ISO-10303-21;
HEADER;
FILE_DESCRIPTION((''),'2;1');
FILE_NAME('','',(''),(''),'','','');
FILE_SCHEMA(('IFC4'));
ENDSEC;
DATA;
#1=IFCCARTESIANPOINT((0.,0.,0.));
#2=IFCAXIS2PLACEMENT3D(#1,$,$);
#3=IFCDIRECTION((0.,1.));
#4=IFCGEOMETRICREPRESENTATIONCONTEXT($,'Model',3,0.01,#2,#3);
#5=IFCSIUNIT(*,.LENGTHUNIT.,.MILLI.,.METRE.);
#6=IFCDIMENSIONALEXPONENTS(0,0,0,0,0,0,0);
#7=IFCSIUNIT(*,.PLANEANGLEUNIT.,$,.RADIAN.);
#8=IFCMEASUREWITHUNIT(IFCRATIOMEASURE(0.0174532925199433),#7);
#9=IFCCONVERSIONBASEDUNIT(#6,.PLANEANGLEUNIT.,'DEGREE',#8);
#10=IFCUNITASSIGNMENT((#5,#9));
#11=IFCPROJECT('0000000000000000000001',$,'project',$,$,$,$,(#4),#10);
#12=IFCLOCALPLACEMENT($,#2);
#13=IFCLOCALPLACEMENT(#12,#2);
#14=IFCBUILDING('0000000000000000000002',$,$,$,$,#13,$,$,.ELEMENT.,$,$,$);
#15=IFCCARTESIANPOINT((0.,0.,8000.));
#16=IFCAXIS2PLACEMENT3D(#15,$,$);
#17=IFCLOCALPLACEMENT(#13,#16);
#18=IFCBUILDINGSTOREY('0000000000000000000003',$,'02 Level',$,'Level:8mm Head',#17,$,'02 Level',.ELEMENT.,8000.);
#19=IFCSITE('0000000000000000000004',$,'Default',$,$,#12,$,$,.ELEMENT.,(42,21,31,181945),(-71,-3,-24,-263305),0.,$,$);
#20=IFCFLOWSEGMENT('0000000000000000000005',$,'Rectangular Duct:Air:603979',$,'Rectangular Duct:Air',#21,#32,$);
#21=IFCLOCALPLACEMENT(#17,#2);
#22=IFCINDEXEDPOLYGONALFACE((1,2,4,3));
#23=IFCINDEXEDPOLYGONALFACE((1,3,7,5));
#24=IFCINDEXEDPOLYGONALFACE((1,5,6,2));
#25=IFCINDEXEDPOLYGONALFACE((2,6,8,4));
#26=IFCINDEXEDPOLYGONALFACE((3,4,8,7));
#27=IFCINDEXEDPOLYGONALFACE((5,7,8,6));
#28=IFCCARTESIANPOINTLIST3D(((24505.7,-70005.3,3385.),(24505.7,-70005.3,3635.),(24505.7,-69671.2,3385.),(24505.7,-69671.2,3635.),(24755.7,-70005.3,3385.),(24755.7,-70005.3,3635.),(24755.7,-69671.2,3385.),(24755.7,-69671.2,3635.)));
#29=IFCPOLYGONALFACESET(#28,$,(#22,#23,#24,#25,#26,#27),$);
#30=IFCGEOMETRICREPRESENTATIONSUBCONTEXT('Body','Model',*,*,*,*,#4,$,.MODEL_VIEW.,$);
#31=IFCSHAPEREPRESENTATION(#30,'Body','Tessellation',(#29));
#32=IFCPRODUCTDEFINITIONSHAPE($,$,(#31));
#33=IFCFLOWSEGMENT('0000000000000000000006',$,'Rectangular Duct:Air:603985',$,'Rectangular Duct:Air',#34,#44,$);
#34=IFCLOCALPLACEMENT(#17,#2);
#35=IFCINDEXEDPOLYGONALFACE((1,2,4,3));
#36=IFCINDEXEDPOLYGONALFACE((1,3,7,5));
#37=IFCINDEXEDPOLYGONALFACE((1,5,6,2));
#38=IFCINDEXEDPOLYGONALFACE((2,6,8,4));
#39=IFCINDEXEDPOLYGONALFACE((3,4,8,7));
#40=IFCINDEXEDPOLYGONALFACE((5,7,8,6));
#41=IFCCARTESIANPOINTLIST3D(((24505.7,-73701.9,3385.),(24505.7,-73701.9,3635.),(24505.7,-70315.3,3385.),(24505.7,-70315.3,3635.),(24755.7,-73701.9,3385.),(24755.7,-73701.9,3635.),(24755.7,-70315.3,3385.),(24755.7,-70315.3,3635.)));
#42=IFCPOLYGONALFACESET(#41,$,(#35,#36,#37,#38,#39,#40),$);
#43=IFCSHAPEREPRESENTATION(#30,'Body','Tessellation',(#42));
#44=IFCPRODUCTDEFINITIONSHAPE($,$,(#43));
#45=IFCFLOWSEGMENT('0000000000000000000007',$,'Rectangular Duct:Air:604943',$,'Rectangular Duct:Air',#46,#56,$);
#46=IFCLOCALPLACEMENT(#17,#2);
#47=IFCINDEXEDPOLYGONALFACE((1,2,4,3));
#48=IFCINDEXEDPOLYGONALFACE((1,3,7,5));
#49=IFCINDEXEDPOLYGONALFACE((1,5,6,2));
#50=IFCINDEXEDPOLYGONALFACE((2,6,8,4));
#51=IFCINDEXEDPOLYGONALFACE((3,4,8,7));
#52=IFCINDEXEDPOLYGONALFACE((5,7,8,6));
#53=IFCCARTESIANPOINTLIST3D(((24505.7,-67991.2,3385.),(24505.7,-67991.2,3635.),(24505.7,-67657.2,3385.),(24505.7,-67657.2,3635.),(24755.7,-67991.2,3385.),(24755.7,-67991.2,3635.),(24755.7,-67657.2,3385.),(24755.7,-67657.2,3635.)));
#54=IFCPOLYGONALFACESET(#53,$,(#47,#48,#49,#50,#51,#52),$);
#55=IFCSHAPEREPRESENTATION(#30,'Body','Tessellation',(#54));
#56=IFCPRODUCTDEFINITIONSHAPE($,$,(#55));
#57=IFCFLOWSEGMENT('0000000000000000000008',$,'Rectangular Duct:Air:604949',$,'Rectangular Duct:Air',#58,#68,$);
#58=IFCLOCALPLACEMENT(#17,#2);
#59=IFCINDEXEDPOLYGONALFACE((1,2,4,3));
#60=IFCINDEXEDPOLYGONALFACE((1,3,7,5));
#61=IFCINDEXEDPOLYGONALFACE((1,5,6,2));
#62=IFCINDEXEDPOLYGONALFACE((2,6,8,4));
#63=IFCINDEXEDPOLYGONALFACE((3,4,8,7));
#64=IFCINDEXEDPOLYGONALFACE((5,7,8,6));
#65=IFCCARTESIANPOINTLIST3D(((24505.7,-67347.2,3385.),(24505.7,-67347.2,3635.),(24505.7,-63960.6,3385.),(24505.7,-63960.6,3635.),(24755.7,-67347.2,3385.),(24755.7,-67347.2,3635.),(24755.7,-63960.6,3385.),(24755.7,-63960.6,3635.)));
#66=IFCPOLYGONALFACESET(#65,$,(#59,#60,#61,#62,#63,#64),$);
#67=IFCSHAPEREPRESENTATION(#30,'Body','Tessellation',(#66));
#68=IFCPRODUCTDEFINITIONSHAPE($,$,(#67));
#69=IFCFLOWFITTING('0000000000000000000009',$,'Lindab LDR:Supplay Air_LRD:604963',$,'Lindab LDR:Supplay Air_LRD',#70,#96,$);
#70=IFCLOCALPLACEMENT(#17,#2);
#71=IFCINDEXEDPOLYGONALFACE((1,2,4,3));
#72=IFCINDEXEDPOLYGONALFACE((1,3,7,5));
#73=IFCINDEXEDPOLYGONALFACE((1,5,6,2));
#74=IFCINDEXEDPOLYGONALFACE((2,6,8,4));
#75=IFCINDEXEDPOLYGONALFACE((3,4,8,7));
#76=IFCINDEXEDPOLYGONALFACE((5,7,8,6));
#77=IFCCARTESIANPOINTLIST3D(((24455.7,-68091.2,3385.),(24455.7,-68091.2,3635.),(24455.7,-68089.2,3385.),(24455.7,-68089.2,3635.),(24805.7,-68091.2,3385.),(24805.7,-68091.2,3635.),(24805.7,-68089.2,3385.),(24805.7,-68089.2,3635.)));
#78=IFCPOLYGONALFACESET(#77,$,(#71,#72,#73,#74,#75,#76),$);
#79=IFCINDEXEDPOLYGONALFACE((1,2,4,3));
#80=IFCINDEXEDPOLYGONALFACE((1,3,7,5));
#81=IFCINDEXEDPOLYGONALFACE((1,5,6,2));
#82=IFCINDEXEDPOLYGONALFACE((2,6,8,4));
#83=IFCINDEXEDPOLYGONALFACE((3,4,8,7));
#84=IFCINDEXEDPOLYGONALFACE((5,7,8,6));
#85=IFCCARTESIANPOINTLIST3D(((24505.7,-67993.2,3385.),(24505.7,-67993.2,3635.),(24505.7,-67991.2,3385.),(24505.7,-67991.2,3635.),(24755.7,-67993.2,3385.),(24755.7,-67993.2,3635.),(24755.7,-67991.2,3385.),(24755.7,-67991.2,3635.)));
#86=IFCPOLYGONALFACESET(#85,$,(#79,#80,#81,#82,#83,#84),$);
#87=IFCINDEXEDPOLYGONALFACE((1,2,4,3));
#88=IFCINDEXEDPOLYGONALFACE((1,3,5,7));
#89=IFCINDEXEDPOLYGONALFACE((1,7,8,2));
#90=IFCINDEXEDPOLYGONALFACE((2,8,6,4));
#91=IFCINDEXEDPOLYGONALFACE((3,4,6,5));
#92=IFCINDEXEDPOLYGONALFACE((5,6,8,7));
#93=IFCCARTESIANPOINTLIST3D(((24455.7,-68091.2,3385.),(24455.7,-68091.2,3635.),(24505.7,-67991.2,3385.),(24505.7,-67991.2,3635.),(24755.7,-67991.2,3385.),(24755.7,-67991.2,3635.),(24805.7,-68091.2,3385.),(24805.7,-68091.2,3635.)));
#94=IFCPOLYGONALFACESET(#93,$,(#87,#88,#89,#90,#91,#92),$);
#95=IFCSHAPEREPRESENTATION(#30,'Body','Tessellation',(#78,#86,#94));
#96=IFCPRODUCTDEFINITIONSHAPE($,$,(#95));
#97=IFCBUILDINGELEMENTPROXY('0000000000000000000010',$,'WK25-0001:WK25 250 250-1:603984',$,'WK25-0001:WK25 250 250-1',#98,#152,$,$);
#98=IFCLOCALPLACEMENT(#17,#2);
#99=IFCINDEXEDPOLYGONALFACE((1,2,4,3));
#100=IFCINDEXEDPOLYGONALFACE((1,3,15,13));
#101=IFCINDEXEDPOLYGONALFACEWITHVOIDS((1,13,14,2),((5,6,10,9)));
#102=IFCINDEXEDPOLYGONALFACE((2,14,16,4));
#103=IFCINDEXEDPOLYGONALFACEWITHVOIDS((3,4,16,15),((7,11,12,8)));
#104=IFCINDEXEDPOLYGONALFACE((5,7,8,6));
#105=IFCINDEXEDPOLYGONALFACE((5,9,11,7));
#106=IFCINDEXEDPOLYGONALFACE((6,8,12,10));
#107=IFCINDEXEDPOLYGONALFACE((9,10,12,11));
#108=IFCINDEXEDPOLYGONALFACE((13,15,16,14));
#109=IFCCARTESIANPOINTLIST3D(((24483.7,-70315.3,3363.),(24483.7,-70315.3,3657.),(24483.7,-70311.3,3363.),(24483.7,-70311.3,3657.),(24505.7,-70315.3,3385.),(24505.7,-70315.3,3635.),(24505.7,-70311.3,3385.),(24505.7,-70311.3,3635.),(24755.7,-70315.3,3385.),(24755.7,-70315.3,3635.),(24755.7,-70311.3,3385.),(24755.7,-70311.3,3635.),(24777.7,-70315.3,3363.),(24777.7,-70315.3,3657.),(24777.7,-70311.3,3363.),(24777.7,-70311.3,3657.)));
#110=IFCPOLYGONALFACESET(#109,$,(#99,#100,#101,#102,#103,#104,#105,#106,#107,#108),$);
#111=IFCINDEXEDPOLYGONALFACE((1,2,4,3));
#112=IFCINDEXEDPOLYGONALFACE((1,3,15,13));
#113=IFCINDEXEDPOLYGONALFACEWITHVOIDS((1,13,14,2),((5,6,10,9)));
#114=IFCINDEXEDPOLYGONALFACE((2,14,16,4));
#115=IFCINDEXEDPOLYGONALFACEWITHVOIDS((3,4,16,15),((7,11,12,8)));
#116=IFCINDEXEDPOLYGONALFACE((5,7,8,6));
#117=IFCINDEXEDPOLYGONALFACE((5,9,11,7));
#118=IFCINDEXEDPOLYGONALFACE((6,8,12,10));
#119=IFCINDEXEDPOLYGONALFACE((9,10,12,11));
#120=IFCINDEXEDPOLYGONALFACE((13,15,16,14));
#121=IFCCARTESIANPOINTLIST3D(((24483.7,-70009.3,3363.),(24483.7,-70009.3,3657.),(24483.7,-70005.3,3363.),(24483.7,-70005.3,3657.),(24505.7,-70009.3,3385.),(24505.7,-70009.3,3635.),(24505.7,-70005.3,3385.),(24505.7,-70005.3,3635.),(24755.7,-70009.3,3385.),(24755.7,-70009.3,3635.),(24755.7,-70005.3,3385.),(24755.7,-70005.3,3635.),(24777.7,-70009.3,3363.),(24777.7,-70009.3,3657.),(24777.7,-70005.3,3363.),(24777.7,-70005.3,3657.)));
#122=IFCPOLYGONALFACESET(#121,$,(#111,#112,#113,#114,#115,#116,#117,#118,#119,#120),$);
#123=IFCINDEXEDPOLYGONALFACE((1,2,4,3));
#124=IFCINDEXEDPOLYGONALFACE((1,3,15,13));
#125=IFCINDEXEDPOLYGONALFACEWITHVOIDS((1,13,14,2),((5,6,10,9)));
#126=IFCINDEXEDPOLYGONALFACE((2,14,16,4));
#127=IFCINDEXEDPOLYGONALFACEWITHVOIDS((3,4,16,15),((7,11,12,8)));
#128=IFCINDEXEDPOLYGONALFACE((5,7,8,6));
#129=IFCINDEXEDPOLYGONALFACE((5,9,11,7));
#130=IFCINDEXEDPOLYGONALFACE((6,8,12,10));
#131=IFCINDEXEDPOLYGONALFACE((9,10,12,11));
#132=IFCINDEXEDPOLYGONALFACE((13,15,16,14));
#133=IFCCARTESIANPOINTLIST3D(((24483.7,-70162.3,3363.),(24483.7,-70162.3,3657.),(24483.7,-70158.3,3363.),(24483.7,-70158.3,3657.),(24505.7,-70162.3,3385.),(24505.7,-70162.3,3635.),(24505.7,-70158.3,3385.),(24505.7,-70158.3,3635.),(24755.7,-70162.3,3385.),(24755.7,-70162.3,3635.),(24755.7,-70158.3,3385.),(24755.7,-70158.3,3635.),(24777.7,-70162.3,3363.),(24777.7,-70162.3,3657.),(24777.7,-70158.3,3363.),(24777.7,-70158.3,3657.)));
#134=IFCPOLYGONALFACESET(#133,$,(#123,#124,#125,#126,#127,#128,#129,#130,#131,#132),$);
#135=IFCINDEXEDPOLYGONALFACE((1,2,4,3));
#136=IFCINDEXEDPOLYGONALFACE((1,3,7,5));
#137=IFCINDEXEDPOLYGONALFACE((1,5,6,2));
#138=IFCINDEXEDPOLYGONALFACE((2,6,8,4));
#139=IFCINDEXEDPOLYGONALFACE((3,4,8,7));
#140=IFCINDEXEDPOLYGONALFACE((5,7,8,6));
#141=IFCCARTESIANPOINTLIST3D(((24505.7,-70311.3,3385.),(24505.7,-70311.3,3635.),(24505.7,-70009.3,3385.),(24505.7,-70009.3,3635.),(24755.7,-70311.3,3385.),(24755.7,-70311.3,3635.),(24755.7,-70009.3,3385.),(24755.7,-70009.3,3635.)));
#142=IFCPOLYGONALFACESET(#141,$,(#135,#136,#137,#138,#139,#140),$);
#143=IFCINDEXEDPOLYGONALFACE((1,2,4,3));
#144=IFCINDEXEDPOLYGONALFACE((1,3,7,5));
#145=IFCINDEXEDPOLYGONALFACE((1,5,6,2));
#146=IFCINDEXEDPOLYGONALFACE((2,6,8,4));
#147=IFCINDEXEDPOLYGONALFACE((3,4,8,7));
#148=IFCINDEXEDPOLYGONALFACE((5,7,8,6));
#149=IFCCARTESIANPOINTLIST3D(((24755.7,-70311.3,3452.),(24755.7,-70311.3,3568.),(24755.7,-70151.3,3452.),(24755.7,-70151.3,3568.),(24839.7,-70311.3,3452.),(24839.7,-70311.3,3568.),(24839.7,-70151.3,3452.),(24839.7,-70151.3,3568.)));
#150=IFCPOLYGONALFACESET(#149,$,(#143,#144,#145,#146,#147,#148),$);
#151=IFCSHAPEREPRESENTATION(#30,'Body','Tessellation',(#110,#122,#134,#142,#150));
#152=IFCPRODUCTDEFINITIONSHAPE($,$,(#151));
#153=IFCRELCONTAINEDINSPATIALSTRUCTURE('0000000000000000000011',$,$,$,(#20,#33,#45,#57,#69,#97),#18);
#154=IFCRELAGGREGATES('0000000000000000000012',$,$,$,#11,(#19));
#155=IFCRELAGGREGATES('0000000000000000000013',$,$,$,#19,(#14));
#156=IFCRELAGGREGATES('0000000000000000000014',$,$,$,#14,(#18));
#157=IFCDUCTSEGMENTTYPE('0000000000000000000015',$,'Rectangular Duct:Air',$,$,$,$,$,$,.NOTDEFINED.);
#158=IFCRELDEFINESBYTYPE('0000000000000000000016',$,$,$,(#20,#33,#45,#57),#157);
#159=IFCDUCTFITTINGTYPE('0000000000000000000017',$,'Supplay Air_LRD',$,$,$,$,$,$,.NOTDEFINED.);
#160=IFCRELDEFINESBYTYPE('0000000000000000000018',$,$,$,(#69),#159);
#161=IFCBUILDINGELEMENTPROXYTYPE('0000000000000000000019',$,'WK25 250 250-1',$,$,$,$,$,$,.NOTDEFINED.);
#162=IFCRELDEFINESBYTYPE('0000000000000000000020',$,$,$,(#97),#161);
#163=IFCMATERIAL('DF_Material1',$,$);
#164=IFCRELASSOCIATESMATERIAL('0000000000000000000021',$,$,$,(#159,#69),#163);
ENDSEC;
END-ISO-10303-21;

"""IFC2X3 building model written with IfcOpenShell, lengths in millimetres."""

from ifc_helpers import new_model, entity, si_unit, converted_unit, direction, frame, frame_2d, origin, origin_2d_with_axis, place, context, subcontext, project, spatial, polyline, rectangle, outline, extrude, source, transform, mapped, material, type_object, type_shapes, element, save


model = new_model("IFC2X3")

# Units and contexts
model_context = context("Model", 3, precision=0.01, world=origin(), true_north=direction((0.0, 1.0)))
body_context = subcontext(model_context, "Body", "Model", "MODEL_VIEW")
ifc_project = project(units=[si_unit("LENGTHUNIT", "METRE", prefix="MILLI"), converted_unit("PLANEANGLEUNIT", "DEGREE", entity("IfcRatioMeasure", 0.0174532925199433), si_unit("PLANEANGLEUNIT", "RADIAN"), dimensions=[0, 0, 0, 0, 0, 0, 0])], contexts=[model_context])

# Site, building, storey
site_placement = place(None, origin())
site = spatial("IfcSite", under=ifc_project, at=site_placement, Name="Default", CompositionType="ELEMENT", RefLatitude=(42, 21, 31, 181945), RefLongitude=(-71, -3, -24, -263305), RefElevation=0.0)
building_placement = place(site_placement, origin())
building = spatial("IfcBuilding", under=site, at=building_placement, CompositionType="ELEMENT")
storey_placement = place(building_placement, frame((0.0, 0.0, 8000.0)))
storey = spatial("IfcBuildingStorey", under=building, at=storey_placement, Name="02 Level", ObjectType="Level:8mm Head", LongName="02 Level", CompositionType="ELEMENT", Elevation=8000.0)

# Flow segments
duct_segment_type_1 = type_object("IfcDuctSegmentType", Name="Rectangular Duct:Air", PredefinedType="NOTDEFINED")
flow_segment_1_placement = place(storey_placement, frame((24505.7, -70005.3, 3385.0)))
element("IfcFlowSegment", 1, at=flow_segment_1_placement, inside=storey, type_object=duct_segment_type_1, Name="Rectangular Duct:Air:603979", ObjectType="Rectangular Duct:Air", context=body_context, shape_type="SweptSolid", body=[
    extrude(rectangle(XDim=334.0, YDim=250.0, at=frame_2d((0.0, 0.0), x_axis=(1.0, 0.0))), frame((125.0, 167.0, 0.0), z_axis=(0.0, 0.0, 1.0), x_axis=(0.0, 1.0, 0.0)), (0.0, 0.0, 1.0), 250.0),
])
flow_segment_2_placement = place(storey_placement, frame((24505.7, -73701.9, 3385.0)))
element("IfcFlowSegment", 2, at=flow_segment_2_placement, inside=storey, type_object=duct_segment_type_1, Name="Rectangular Duct:Air:603985", ObjectType="Rectangular Duct:Air", context=body_context, shape_type="SweptSolid", body=[
    extrude(rectangle(XDim=3386.6, YDim=250.0, at=frame_2d((0.0, 0.0), x_axis=(1.0, 0.0))), frame((125.0, 1693.3, 0.0), z_axis=(0.0, 0.0, 1.0), x_axis=(0.0, 1.0, 0.0)), (0.0, 0.0, 1.0), 250.0),
])
flow_segment_3_placement = place(storey_placement, frame((24505.7, -67991.2, 3385.0)))
element("IfcFlowSegment", 3, at=flow_segment_3_placement, inside=storey, type_object=duct_segment_type_1, Name="Rectangular Duct:Air:604943", ObjectType="Rectangular Duct:Air", context=body_context, shape_type="SweptSolid", body=[
    extrude(rectangle(XDim=334.0, YDim=250.0, at=frame_2d((0.0, 0.0), x_axis=(1.0, 0.0))), frame((125.0, 167.0, 0.0), z_axis=(0.0, 0.0, 1.0), x_axis=(0.0, -1.0, 0.0)), (0.0, 0.0, 1.0), 250.0),
])
flow_segment_4_placement = place(storey_placement, frame((24505.7, -67347.2, 3385.0)))
element("IfcFlowSegment", 4, at=flow_segment_4_placement, inside=storey, type_object=duct_segment_type_1, Name="Rectangular Duct:Air:604949", ObjectType="Rectangular Duct:Air", context=body_context, shape_type="SweptSolid", body=[
    extrude(rectangle(XDim=3386.6, YDim=250.0, at=frame_2d((0.0, 0.0), x_axis=(1.0, 0.0))), frame((125.0, 1693.3, 0.0), z_axis=(0.0, 0.0, 1.0), x_axis=(0.0, -1.0, 0.0)), (0.0, 0.0, 1.0), 250.0),
])

# Flow fitting
ifc_material = material(Name="DF_Material1")
duct_fitting_type_1 = type_object("IfcDuctFittingType", Name="Supplay Air_LRD", PredefinedType="NOTDEFINED", material=ifc_material)
shared_shape_1 = source(origin(), body_context, "Body", "SweptSolid", [
    extrude(rectangle(XDim=350.0, YDim=2.0, at=origin_2d_with_axis()), frame((99.0, 0.0, -125.0), z_axis=(0.0, 0.0, 1.0), x_axis=(0.0, 1.0, 0.0)), (0.0, 0.0, 1.0), 250.0),
    extrude(rectangle(XDim=250.0, YDim=2.0, at=origin_2d_with_axis()), frame((1.0, 0.0, -125.0), z_axis=(0.0, 0.0, 1.0), x_axis=(0.0, 1.0, 0.0)), (0.0, 0.0, 1.0), 250.0),
    extrude(outline(polyline([(-125.0, -50.0), (125.0, -50.0), (175.0, 50.0), (-175.0, 50.0), (-125.0, -50.0)])), frame((50.0, 0.0, -125.0), z_axis=(0.0, 0.0, 1.0), x_axis=(0.0, -1.0, 0.0)), (0.0, 0.0, 1.0), 250.0),
])
type_shapes(duct_fitting_type_1, [shared_shape_1])
flow_fitting_1_placement = place(storey_placement, frame((24630.7, -67991.2, 3510.0), z_axis=(0.0, 0.0, 1.0), x_axis=(0.0, -1.0, 0.0)))
element("IfcFlowFitting", 5, at=flow_fitting_1_placement, inside=storey, type_object=duct_fitting_type_1, material=ifc_material, Name="Lindab LDR:Supplay Air_LRD:604963", ObjectType="Lindab LDR:Supplay Air_LRD", context=body_context, shape_type="MappedRepresentation", body=[
    mapped(shared_shape_1, transform((0.0, 0.0, 0.0), scale=1.0)),
])

# Building element proxy
building_element_proxy_type_1 = type_object("IfcBuildingElementProxyType", Name="WK25 250 250-1", PredefinedType="NOTDEFINED")
shared_shape_2 = source(origin(), body_context, "Body", "SweptSolid", [
    extrude(outline(polyline([(-147.0, -147.0), (147.0, -147.0), (147.0, 147.0), (-147.0, 147.0), (-147.0, -147.0)]), holes=[polyline([(-125.0, -125.0), (-125.0, 125.0), (125.0, 125.0), (125.0, -125.0), (-125.0, -125.0)])]), frame((151.0, 0.0, 0.0), z_axis=(1.0, 0.0, 0.0), x_axis=(0.0, 0.0, -1.0)), (0.0, 0.0, 1.0), 4.0),
    extrude(outline(polyline([(-147.0, -147.0), (147.0, -147.0), (147.0, 147.0), (-147.0, 147.0), (-147.0, -147.0)]), holes=[polyline([(-125.0, -125.0), (-125.0, 125.0), (125.0, 125.0), (125.0, -125.0), (-125.0, -125.0)])]), frame((-155.0, 0.0, 0.0), z_axis=(1.0, 0.0, 0.0), x_axis=(0.0, -1.0, 0.0)), (0.0, 0.0, 1.0), 4.0),
    extrude(outline(polyline([(-147.0, -147.0), (147.0, -147.0), (147.0, 147.0), (-147.0, 147.0), (-147.0, -147.0)]), holes=[polyline([(-125.0, -125.0), (-125.0, 125.0), (125.0, 125.0), (125.0, -125.0), (-125.0, -125.0)])]), frame((-2.0, 0.0, 0.0), z_axis=(1.0, 0.0, 0.0), x_axis=(0.0, -1.0, 0.0)), (0.0, 0.0, 1.0), 4.0),
    extrude(rectangle(XDim=302.0, YDim=250.0, at=origin_2d_with_axis()), frame((0.0, 0.0, -125.0), z_axis=(0.0, 0.0, 1.0), x_axis=(-1.0, 0.0, 0.0)), (0.0, 0.0, 1.0), 250.0),
    extrude(rectangle(XDim=84.0, YDim=160.0, at=frame_2d((0.0, 0.0), x_axis=(1.0, 0.0))), frame((71.0, -167.0, -58.0), z_axis=(0.0, 0.0, 1.0), x_axis=(0.0, -1.0, 0.0)), (0.0, 0.0, 1.0), 116.0),
])
type_shapes(building_element_proxy_type_1, [shared_shape_2])
proxy_1_placement = place(storey_placement, frame((24630.7, -70160.3, 3510.0), z_axis=(0.0, 0.0, -1.0), x_axis=(0.0, -1.0, 0.0)))
element("IfcBuildingElementProxy", 6, at=proxy_1_placement, inside=storey, type_object=building_element_proxy_type_1, Name="WK25-0001:WK25 250 250-1:603984", ObjectType="WK25-0001:WK25 250 250-1", context=body_context, shape_type="MappedRepresentation", body=[
    mapped(shared_shape_2, transform((0.0, 0.0, 0.0), scale=1.0)),
])

save(model, "model.ifc")
